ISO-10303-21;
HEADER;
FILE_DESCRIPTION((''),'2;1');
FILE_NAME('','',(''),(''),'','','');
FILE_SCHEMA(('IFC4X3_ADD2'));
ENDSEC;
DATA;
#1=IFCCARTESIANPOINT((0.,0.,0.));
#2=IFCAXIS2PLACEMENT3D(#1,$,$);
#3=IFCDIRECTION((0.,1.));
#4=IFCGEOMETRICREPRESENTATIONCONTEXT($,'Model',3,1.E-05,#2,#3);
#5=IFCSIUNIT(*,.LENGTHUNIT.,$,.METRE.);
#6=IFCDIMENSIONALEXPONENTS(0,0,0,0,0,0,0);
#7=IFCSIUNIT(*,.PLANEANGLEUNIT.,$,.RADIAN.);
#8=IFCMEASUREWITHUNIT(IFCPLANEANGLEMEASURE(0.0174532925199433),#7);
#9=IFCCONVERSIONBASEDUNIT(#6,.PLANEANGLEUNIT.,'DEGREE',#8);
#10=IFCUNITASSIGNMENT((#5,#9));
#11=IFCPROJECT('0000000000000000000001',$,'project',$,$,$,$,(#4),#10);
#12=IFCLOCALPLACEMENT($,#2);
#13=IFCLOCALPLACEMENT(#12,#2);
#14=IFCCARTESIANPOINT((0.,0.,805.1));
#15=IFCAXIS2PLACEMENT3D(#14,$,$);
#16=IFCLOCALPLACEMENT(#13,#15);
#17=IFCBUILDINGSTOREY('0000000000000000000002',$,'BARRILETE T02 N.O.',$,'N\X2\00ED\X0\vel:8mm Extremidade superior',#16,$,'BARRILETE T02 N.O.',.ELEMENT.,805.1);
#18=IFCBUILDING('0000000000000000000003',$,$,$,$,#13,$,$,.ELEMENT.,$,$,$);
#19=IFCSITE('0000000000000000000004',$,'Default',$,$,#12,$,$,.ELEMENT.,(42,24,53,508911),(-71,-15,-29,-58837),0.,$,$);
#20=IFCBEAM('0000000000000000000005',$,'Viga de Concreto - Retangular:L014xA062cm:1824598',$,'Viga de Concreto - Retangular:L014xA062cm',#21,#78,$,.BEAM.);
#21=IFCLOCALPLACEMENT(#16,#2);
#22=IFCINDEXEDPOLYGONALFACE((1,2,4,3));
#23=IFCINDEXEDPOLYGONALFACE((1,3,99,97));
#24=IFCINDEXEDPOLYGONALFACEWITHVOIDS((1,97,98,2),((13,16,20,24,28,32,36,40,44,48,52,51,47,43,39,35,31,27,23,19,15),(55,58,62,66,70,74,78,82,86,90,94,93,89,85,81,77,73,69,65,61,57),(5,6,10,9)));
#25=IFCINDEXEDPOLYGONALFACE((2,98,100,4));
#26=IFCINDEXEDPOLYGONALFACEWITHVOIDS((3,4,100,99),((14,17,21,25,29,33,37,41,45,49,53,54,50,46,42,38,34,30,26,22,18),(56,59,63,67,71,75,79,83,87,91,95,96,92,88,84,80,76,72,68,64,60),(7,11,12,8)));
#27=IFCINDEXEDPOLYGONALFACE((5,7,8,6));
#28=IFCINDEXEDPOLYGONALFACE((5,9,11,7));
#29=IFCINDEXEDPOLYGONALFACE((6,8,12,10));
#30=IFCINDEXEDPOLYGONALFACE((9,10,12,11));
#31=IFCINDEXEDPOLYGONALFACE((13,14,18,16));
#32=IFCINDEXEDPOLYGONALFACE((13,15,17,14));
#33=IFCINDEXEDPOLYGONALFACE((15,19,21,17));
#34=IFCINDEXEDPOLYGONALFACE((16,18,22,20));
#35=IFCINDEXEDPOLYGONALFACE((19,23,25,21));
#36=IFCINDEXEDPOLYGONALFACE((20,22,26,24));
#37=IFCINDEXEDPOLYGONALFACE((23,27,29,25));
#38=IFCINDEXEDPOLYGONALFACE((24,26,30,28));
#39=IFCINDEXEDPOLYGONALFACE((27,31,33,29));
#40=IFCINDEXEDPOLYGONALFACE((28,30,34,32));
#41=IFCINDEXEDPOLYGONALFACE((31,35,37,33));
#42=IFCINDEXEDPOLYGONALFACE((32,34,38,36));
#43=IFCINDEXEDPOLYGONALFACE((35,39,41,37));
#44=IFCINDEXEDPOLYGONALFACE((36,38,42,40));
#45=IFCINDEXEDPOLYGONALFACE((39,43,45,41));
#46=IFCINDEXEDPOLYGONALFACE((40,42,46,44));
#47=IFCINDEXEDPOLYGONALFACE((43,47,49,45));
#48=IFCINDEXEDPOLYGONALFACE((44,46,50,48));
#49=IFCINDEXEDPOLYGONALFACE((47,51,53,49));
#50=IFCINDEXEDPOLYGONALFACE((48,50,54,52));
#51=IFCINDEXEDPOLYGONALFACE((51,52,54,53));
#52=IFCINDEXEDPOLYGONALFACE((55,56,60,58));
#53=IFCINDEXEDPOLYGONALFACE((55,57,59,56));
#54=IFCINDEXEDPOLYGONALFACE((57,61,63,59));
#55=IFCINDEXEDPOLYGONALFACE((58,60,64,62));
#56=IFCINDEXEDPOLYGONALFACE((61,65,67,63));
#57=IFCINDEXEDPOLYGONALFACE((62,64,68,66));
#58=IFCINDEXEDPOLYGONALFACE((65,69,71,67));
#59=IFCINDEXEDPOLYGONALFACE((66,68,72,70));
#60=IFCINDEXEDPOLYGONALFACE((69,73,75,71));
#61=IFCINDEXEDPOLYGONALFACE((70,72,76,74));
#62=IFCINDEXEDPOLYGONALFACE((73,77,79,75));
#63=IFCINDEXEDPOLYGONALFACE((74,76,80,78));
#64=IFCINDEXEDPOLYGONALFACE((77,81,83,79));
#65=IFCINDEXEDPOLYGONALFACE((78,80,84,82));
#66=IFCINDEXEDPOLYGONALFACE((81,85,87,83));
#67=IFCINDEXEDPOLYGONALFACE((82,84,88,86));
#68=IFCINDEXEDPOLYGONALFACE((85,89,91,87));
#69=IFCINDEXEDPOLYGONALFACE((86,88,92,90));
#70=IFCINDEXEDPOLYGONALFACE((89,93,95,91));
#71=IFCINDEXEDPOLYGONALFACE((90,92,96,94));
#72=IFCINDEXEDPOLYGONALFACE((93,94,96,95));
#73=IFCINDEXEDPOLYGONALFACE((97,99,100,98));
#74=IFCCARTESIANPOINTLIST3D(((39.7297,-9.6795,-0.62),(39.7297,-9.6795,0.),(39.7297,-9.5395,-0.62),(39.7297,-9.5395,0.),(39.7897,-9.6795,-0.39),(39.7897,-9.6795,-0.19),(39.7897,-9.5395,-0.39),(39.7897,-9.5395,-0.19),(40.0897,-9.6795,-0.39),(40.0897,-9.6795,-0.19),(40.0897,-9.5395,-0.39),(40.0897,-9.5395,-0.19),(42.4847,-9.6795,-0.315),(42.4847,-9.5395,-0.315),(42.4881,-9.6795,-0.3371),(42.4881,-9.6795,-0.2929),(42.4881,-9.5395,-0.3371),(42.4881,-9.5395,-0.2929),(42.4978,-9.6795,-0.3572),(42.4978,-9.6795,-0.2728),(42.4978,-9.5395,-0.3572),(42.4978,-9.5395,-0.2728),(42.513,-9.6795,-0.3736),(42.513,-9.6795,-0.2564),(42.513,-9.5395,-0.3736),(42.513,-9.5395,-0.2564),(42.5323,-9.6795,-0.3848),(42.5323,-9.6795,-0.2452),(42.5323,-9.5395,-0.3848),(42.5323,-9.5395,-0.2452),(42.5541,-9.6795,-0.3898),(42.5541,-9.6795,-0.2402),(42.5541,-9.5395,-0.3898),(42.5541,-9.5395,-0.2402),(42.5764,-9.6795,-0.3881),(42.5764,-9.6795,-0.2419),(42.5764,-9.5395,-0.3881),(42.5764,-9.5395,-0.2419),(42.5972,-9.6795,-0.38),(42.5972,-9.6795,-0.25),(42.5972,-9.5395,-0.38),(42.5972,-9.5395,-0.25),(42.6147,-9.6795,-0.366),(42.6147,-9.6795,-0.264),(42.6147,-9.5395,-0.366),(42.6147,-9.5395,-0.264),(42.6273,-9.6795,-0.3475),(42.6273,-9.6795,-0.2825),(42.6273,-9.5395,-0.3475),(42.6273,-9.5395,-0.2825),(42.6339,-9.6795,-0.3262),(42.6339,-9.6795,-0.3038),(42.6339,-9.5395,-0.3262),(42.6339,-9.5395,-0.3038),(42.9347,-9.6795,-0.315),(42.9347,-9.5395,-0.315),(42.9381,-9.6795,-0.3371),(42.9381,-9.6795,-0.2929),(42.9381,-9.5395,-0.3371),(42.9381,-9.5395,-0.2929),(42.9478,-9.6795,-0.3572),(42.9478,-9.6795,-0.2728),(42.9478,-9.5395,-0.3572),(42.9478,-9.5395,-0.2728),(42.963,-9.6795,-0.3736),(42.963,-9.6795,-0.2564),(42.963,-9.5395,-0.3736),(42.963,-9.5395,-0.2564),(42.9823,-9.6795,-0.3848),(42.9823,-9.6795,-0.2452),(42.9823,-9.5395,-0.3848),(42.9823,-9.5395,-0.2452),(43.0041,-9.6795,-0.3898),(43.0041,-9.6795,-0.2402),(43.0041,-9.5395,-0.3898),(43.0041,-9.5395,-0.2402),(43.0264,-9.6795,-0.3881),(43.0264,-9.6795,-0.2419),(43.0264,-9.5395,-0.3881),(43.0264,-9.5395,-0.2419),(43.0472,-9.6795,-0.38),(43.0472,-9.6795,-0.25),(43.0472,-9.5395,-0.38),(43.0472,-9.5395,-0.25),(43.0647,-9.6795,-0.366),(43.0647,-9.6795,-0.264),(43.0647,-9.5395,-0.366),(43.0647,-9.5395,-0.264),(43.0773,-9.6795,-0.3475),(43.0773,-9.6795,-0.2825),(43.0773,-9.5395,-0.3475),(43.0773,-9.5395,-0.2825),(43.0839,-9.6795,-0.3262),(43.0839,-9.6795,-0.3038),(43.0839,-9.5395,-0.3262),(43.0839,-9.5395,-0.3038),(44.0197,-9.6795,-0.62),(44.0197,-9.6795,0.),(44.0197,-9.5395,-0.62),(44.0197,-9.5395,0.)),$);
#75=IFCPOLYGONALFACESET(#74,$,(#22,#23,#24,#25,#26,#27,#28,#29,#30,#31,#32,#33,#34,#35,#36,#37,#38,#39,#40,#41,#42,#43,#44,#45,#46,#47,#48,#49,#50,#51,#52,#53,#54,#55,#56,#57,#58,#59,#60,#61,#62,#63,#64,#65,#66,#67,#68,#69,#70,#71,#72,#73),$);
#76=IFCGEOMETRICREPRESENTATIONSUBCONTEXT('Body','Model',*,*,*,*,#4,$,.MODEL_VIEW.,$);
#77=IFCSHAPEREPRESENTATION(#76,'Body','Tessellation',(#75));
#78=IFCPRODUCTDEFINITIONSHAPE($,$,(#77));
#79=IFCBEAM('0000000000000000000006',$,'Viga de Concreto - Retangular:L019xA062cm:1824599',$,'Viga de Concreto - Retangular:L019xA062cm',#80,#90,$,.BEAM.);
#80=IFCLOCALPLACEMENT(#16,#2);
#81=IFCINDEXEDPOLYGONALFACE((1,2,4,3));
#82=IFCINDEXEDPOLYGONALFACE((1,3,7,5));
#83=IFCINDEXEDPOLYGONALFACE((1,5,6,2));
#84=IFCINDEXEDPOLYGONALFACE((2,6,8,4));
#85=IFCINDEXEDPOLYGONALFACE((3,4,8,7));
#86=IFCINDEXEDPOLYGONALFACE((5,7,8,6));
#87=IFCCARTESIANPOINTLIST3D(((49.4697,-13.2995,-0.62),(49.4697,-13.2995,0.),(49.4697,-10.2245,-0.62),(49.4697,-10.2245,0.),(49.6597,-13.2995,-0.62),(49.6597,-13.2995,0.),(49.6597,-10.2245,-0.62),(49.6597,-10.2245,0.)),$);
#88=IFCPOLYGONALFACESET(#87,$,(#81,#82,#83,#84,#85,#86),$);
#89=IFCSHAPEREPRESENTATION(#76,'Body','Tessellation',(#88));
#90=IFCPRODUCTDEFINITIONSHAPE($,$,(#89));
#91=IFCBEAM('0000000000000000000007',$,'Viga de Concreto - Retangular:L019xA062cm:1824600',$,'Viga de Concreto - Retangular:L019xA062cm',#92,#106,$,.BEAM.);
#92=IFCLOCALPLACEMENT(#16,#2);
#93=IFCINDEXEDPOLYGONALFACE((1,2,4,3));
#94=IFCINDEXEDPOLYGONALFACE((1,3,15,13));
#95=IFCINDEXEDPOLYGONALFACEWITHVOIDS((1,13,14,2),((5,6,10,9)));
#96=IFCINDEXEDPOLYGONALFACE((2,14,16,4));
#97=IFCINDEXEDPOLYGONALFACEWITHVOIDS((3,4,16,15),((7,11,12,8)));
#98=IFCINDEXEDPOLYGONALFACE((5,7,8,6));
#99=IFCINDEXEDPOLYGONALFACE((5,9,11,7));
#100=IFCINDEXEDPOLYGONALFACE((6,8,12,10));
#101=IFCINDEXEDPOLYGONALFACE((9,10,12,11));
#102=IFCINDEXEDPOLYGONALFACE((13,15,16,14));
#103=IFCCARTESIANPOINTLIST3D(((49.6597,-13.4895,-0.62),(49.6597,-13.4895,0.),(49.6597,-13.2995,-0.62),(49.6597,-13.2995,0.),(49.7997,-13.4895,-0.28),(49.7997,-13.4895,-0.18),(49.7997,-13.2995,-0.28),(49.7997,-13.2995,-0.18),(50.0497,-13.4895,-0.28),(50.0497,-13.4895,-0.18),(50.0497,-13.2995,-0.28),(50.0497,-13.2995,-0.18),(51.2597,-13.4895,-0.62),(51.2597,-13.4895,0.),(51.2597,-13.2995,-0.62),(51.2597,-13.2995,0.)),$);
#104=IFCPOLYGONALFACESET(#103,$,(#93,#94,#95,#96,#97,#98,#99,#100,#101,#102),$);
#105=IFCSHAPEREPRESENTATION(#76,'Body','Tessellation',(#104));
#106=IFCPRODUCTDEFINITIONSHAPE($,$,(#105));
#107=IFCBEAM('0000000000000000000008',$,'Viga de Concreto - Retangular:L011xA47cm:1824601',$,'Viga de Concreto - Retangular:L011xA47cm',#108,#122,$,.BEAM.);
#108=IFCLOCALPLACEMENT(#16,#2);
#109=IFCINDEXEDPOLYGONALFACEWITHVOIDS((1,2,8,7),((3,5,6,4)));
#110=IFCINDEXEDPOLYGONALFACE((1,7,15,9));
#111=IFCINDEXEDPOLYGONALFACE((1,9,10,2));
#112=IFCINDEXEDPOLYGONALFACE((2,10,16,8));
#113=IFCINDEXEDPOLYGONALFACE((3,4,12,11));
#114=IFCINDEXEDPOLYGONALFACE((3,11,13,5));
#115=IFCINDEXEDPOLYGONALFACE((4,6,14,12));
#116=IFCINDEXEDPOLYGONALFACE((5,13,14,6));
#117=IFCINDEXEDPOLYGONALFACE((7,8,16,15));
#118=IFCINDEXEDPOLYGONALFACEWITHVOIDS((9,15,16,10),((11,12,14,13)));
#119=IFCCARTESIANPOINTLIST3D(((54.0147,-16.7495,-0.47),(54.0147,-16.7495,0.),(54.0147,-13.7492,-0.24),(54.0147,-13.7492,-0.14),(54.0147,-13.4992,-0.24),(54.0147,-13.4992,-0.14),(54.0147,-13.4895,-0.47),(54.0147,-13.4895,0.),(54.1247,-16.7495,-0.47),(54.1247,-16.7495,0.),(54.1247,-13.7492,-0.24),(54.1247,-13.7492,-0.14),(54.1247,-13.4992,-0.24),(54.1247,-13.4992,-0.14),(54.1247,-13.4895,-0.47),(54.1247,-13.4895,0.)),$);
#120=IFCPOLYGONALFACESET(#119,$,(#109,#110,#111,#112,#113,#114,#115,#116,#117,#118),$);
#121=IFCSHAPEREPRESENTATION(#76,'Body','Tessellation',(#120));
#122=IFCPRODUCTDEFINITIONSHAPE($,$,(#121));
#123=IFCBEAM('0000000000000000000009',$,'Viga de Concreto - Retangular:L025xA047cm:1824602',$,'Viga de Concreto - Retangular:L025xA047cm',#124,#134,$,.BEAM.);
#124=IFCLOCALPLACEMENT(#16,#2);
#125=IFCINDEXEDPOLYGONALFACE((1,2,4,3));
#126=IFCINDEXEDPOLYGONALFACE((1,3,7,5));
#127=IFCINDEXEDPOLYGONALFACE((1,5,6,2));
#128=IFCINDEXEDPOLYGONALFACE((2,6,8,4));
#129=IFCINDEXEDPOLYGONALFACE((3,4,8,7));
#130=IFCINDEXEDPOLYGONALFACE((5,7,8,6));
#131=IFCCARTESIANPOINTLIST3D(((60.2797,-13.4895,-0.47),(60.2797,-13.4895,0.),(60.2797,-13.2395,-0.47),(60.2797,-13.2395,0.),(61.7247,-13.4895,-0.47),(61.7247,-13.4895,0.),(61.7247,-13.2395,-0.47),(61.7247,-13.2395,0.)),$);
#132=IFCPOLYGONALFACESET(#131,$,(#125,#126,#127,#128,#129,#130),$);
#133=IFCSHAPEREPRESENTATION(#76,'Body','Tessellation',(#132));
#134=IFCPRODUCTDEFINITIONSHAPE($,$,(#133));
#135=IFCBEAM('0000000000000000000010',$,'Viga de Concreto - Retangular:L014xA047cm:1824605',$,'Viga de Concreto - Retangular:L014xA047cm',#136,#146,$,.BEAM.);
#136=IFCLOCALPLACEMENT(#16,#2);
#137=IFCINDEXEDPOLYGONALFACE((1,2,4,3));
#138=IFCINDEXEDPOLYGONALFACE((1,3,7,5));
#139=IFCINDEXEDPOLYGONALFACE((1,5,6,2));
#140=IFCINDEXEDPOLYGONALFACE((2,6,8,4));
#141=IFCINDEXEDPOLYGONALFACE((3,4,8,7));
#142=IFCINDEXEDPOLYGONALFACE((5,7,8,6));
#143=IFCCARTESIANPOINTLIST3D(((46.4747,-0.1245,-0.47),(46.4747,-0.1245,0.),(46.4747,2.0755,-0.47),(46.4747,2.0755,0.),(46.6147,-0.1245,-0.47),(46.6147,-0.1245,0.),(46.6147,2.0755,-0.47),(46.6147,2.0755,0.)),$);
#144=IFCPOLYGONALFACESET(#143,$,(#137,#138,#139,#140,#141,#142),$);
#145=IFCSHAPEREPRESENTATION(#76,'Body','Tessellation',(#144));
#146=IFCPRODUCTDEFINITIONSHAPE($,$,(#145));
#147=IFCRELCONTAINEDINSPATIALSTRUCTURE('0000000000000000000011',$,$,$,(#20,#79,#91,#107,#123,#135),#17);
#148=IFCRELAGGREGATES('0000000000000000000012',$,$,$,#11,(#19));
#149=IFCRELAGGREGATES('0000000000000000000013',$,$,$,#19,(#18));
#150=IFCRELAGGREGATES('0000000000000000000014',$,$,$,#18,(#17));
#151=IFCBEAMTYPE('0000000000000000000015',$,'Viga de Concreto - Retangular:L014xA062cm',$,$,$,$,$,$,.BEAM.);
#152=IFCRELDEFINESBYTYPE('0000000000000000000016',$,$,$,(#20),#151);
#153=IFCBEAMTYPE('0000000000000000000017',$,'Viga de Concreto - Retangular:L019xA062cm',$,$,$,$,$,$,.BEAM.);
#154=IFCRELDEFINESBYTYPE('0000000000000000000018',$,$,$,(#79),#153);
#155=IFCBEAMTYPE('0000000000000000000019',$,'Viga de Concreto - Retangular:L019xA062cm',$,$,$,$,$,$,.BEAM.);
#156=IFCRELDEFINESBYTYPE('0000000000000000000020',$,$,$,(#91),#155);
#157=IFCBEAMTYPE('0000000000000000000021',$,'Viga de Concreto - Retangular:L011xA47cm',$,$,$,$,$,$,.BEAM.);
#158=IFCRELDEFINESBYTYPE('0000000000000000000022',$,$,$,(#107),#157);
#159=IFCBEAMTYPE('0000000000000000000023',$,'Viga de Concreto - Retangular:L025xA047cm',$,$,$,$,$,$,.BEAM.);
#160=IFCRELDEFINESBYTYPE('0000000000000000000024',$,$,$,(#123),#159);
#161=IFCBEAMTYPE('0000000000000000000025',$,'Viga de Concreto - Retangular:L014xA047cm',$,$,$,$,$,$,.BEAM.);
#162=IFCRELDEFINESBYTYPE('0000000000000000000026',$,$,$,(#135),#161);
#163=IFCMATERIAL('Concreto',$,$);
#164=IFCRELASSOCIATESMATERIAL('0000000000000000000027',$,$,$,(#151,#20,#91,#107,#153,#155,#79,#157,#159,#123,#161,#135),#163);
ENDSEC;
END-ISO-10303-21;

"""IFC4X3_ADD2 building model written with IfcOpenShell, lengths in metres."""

from ifc_helpers import new_model, entity, si_unit, converted_unit, direction, frame, frame_2d, origin, origin_2d_with_axis, place, context, subcontext, project, spatial, polyline, segment, composite_curve, rectangle, circle, outline, extrude, boolean, source, transform, mapped, material, material_profile, profile_set, profile_usage, type_object, type_shapes, element, save


model = new_model("IFC4X3_ADD2")

# Units and contexts
model_context = context("Model", 3, precision=1e-05, world=origin(), true_north=direction((0.0, 1.0)))
body_context = subcontext(model_context, "Body", "Model", "MODEL_VIEW")
ifc_project = project(units=[si_unit("LENGTHUNIT", "METRE"), converted_unit("PLANEANGLEUNIT", "DEGREE", entity("IfcPlaneAngleMeasure", 0.0174532925199433), si_unit("PLANEANGLEUNIT", "RADIAN"), dimensions=[0, 0, 0, 0, 0, 0, 0])], contexts=[model_context])

# Site, building, storey
site_placement = place(None, origin())
site = spatial("IfcSite", under=ifc_project, at=site_placement, Name="Default", CompositionType="ELEMENT", RefLatitude=(42, 24, 53, 508911), RefLongitude=(-71, -15, -29, -58837), RefElevation=0.0)
building_placement = place(site_placement, origin())
building = spatial("IfcBuilding", under=site, at=building_placement, CompositionType="ELEMENT")
storey_placement = place(building_placement, frame((0.0, 0.0, 805.1)))
storey = spatial("IfcBuildingStorey", under=building, at=storey_placement, Name="BARRILETE T02 N.O.", ObjectType="Nível:8mm Extremidade superior", LongName="BARRILETE T02 N.O.", CompositionType="ELEMENT", Elevation=805.1)

# Shared definitions
ifc_material = material(Name="Concreto")

# Beams
ifc_material_profile_1 = material_profile(ifc_material, rectangle(XDim=0.62, YDim=0.19, at=frame_2d((0.0, 0.0), x_axis=(0.0, 1.0))), Name="L019xA062cm")
ifc_profile_set_1 = profile_set([ifc_material_profile_1], Name="L019xA062cm")
ifc_profile_usage_1 = profile_usage(ifc_profile_set_1, cardinal=8)
ifc_material_profile_2 = material_profile(ifc_material, outline(composite_curve([segment(polyline([(-0.07, 0.31, 0.0), (0.07, 0.31, 0.0)]), True, "CONTINUOUS"), segment(polyline([(0.07, 0.31, 0.0), (0.07, -0.31, 0.0)]), True, "CONTINUOUS"), segment(polyline([(0.07, -0.31, 0.0), (-0.07, -0.31, 0.0)]), True, "CONTINUOUS"), segment(polyline([(-0.07, -0.31, 0.0), (-0.07, 0.31, 0.0)]), True, "CONTINUOUS")], self_intersect=False), kind="CURVE"), Name="L014xA062cm")
ifc_material_profile_3 = material_profile(ifc_material, outline(composite_curve([segment(polyline([(-2.2225, 0.07, 0.31), (-2.2225, 0.07, -0.31)]), True, "CONTINUOUS"), segment(polyline([(-2.2225, 0.07, -0.31), (-2.2225, -0.07, -0.31)]), True, "CONTINUOUS"), segment(polyline([(-2.2225, -0.07, -0.31), (-2.2225, -0.07, 0.31)]), True, "CONTINUOUS"), segment(polyline([(-2.2225, -0.07, 0.31), (-2.2225, 0.07, 0.31)]), True, "CONTINUOUS")], self_intersect=False), kind="CURVE"), Name="L014xA062cm")
ifc_profile_set_2 = profile_set([ifc_material_profile_2, ifc_material_profile_3], Name="L014xA062cm")
ifc_material_profile_4 = material_profile(ifc_material, rectangle(XDim=0.47, YDim=0.14, at=frame_2d((0.0, 0.0), x_axis=(0.0, 1.0))), Name="L014xA047cm")
ifc_profile_set_3 = profile_set([ifc_material_profile_4], Name="L014xA047cm")
ifc_profile_usage_2 = profile_usage(ifc_profile_set_3, cardinal=8)
beam_type_1 = type_object("IfcBeamType", Name="Viga de Concreto - Retangular:L014xA062cm", PredefinedType="BEAM", material=ifc_profile_set_2)
shared_shape_1 = source(origin(), body_context, "Body", "CSG", [
    boolean("DIFFERENCE", boolean("DIFFERENCE", boolean("DIFFERENCE", extrude(rectangle(XDim=0.62, YDim=0.14, at=frame_2d((0.0, 0.0), x_axis=(0.0, 1.0))), frame((44.0197, -9.6095, 804.79), z_axis=(-1.0, 0.0, 0.0), x_axis=(0.0, -1.0, 0.0)), (0.0, 0.0, 1.0), 4.29), extrude(circle(Radius=0.075, at=origin_2d_with_axis()), frame((43.0097, -9.5395, 804.785), z_axis=(0.0, -1.0, 0.0), x_axis=(-1.0, 0.0, 0.0)), (0.0, 0.0, 1.0), 0.14)), extrude(circle(Radius=0.075, at=origin_2d_with_axis()), frame((42.5597, -9.5395, 804.785), z_axis=(0.0, -1.0, 0.0), x_axis=(-1.0, 0.0, 0.0)), (0.0, 0.0, 1.0), 0.14)), extrude(rectangle(XDim=0.2, YDim=0.3, at=frame_2d((0.0, 0.0), x_axis=(0.0, 1.0))), frame((39.9397, -9.5395, 804.81), z_axis=(0.0, -1.0, 0.0), x_axis=(-1.0, 0.0, 0.0)), (0.0, 0.0, 1.0), 0.14)),
])
type_shapes(beam_type_1, [shared_shape_1])
beam_1_placement = place(storey_placement, frame((0.0, 0.0, -805.1)))
element("IfcBeam", 1, at=beam_1_placement, inside=storey, type_object=beam_type_1, material=ifc_material, Name="Viga de Concreto - Retangular:L014xA062cm:1824598", ObjectType="Viga de Concreto - Retangular:L014xA062cm", PredefinedType="BEAM", context=body_context, shape_type="MappedRepresentation", body=[
    mapped(shared_shape_1, transform((0.0, 0.0, 0.0), scale=1.0)),
])
beam_type_2 = type_object("IfcBeamType", Name="Viga de Concreto - Retangular:L019xA062cm", PredefinedType="BEAM", material=ifc_profile_set_1)
shared_shape_2 = source(origin(), body_context, "Body", "SweptSolid", [
    extrude(rectangle(XDim=0.62, YDim=0.19, at=frame_2d((0.0, 0.0), x_axis=(0.0, 1.0))), frame((49.5647, -13.2995, 804.79), z_axis=(0.0, 1.0, 0.0), x_axis=(-1.0, 0.0, 0.0)), (0.0, 0.0, 1.0), 3.075),
])
type_shapes(beam_type_2, [shared_shape_2])
beam_2_placement = place(storey_placement, frame((0.0, 0.0, -805.1)))
element("IfcBeam", 2, at=beam_2_placement, inside=storey, type_object=beam_type_2, material=ifc_profile_usage_1, Name="Viga de Concreto - Retangular:L019xA062cm:1824599", ObjectType="Viga de Concreto - Retangular:L019xA062cm", PredefinedType="BEAM", context=body_context, shape_type="MappedRepresentation", body=[
    mapped(shared_shape_2, transform((0.0, 0.0, 0.0), scale=1.0)),
])
beam_type_3 = type_object("IfcBeamType", Name="Viga de Concreto - Retangular:L019xA062cm", PredefinedType="BEAM", material=ifc_profile_set_1)
shared_shape_3 = source(origin(), body_context, "Body", "CSG", [
    boolean("DIFFERENCE", extrude(rectangle(XDim=0.62, YDim=0.19, at=frame_2d((0.0, 0.0), x_axis=(0.0, 1.0))), frame((49.6597, -13.3945, 804.79), z_axis=(1.0, 0.0, 0.0), x_axis=(0.0, 1.0, 0.0)), (0.0, 0.0, 1.0), 1.6), extrude(rectangle(XDim=0.1, YDim=0.25, at=frame_2d((0.0, 0.0), x_axis=(0.0, 1.0))), frame((49.9247, -13.2995, 804.87), z_axis=(0.0, -1.0, 0.0), x_axis=(-1.0, 0.0, 0.0)), (0.0, 0.0, 1.0), 0.19)),
])
type_shapes(beam_type_3, [shared_shape_3])
beam_3_placement = place(storey_placement, frame((0.0, 0.0, -805.1)))
element("IfcBeam", 3, at=beam_3_placement, inside=storey, type_object=beam_type_3, material=ifc_material, Name="Viga de Concreto - Retangular:L019xA062cm:1824600", ObjectType="Viga de Concreto - Retangular:L019xA062cm", PredefinedType="BEAM", context=body_context, shape_type="MappedRepresentation", body=[
    mapped(shared_shape_3, transform((0.0, 0.0, 0.0), scale=1.0)),
])
ifc_material_profile_5 = material_profile(ifc_material, outline(composite_curve([segment(polyline([(-0.055, 0.235, 0.0), (0.055, 0.235, 0.0)]), True, "CONTINUOUS"), segment(polyline([(0.055, 0.235, 0.0), (0.055, -0.235, 0.0)]), True, "CONTINUOUS"), segment(polyline([(0.055, -0.235, 0.0), (-0.055, -0.235, 0.0)]), True, "CONTINUOUS"), segment(polyline([(-0.055, -0.235, 0.0), (-0.055, 0.235, 0.0)]), True, "CONTINUOUS")], self_intersect=False), kind="CURVE"), Name="L011xA47cm")
ifc_material_profile_6 = material_profile(ifc_material, outline(composite_curve([segment(polyline([(1.6775, -0.055, -0.235), (1.6775, -0.055, 0.235)]), True, "CONTINUOUS"), segment(polyline([(1.6775, -0.055, 0.235), (-1.6775, -0.055, 0.235)]), True, "CONTINUOUS"), segment(polyline([(-1.6775, -0.055, 0.235), (-1.6775, -0.055, -0.235)]), True, "CONTINUOUS"), segment(polyline([(-1.6775, -0.055, -0.235), (1.6775, -0.055, -0.235)]), True, "CONTINUOUS")], self_intersect=False), kind="CURVE"), Name="L011xA47cm")
ifc_profile_set_4 = profile_set([ifc_material_profile_5, ifc_material_profile_6], Name="L011xA47cm")
beam_type_4 = type_object("IfcBeamType", Name="Viga de Concreto - Retangular:L011xA47cm", PredefinedType="BEAM", material=ifc_profile_set_4)
shared_shape_4 = source(origin(), body_context, "Body", "CSG", [
    boolean("DIFFERENCE", extrude(rectangle(XDim=0.47, YDim=0.11, at=frame_2d((0.0, 0.0), x_axis=(0.0, 1.0))), frame((54.0697, -16.7495, 804.865), z_axis=(0.0, 1.0, 0.0), x_axis=(-1.0, 0.0, 0.0)), (0.0, 0.0, 1.0), 3.26), extrude(rectangle(XDim=0.1, YDim=0.25, at=frame_2d((0.0, 0.0), x_axis=(0.0, 1.0))), frame((54.1247, -13.6242, 804.91), z_axis=(-1.0, 0.0, 0.0), x_axis=(0.0, 1.0, 0.0)), (0.0, 0.0, 1.0), 0.11)),
])
type_shapes(beam_type_4, [shared_shape_4])
beam_4_placement = place(storey_placement, frame((0.0, 0.0, -805.1)))
element("IfcBeam", 4, at=beam_4_placement, inside=storey, type_object=beam_type_4, material=ifc_material, Name="Viga de Concreto - Retangular:L011xA47cm:1824601", ObjectType="Viga de Concreto - Retangular:L011xA47cm", PredefinedType="BEAM", context=body_context, shape_type="MappedRepresentation", body=[
    mapped(shared_shape_4, transform((0.0, 0.0, 0.0), scale=1.0)),
])
ifc_material_profile_7 = material_profile(ifc_material, rectangle(XDim=0.47, YDim=0.25, at=origin_2d_with_axis()), Name="L025xA047cm")
ifc_profile_set_5 = profile_set([ifc_material_profile_7], Name="L025xA047cm")
ifc_profile_usage_3 = profile_usage(ifc_profile_set_5, cardinal=8)
beam_type_5 = type_object("IfcBeamType", Name="Viga de Concreto - Retangular:L025xA047cm", PredefinedType="BEAM", material=ifc_profile_set_5)
shared_shape_5 = source(origin(), body_context, "Body", "SweptSolid", [
    extrude(rectangle(XDim=0.47, YDim=0.25, at=origin_2d_with_axis()), frame((61.7247, -13.3645, 804.865), z_axis=(-1.0, 0.0, 0.0), x_axis=(0.0, 0.0, -1.0)), (0.0, 0.0, 1.0), 1.445),
])
type_shapes(beam_type_5, [shared_shape_5])
beam_5_placement = place(storey_placement, frame((0.0, 0.0, -805.1)))
element("IfcBeam", 5, at=beam_5_placement, inside=storey, type_object=beam_type_5, material=ifc_profile_usage_3, Name="Viga de Concreto - Retangular:L025xA047cm:1824602", ObjectType="Viga de Concreto - Retangular:L025xA047cm", PredefinedType="BEAM", context=body_context, shape_type="MappedRepresentation", body=[
    mapped(shared_shape_5, transform((0.0, 0.0, 0.0), scale=1.0)),
])
beam_type_6 = type_object("IfcBeamType", Name="Viga de Concreto - Retangular:L014xA047cm", PredefinedType="BEAM", material=ifc_profile_set_3)
shared_shape_6 = source(origin(), body_context, "Body", "SweptSolid", [
    extrude(rectangle(XDim=0.47, YDim=0.14, at=frame_2d((0.0, 0.0), x_axis=(0.0, 1.0))), frame((46.5447, -0.1245, 804.865), z_axis=(0.0, 1.0, 0.0), x_axis=(-1.0, 0.0, 0.0)), (0.0, 0.0, 1.0), 2.2),
])
type_shapes(beam_type_6, [shared_shape_6])
beam_6_placement = place(storey_placement, frame((0.0, 0.0, -805.1)))
element("IfcBeam", 6, at=beam_6_placement, inside=storey, type_object=beam_type_6, material=ifc_profile_usage_2, Name="Viga de Concreto - Retangular:L014xA047cm:1824605", ObjectType="Viga de Concreto - Retangular:L014xA047cm", PredefinedType="BEAM", context=body_context, shape_type="MappedRepresentation", body=[
    mapped(shared_shape_6, transform((0.0, 0.0, 0.0), scale=1.0)),
])

save(model, "model.ifc")
